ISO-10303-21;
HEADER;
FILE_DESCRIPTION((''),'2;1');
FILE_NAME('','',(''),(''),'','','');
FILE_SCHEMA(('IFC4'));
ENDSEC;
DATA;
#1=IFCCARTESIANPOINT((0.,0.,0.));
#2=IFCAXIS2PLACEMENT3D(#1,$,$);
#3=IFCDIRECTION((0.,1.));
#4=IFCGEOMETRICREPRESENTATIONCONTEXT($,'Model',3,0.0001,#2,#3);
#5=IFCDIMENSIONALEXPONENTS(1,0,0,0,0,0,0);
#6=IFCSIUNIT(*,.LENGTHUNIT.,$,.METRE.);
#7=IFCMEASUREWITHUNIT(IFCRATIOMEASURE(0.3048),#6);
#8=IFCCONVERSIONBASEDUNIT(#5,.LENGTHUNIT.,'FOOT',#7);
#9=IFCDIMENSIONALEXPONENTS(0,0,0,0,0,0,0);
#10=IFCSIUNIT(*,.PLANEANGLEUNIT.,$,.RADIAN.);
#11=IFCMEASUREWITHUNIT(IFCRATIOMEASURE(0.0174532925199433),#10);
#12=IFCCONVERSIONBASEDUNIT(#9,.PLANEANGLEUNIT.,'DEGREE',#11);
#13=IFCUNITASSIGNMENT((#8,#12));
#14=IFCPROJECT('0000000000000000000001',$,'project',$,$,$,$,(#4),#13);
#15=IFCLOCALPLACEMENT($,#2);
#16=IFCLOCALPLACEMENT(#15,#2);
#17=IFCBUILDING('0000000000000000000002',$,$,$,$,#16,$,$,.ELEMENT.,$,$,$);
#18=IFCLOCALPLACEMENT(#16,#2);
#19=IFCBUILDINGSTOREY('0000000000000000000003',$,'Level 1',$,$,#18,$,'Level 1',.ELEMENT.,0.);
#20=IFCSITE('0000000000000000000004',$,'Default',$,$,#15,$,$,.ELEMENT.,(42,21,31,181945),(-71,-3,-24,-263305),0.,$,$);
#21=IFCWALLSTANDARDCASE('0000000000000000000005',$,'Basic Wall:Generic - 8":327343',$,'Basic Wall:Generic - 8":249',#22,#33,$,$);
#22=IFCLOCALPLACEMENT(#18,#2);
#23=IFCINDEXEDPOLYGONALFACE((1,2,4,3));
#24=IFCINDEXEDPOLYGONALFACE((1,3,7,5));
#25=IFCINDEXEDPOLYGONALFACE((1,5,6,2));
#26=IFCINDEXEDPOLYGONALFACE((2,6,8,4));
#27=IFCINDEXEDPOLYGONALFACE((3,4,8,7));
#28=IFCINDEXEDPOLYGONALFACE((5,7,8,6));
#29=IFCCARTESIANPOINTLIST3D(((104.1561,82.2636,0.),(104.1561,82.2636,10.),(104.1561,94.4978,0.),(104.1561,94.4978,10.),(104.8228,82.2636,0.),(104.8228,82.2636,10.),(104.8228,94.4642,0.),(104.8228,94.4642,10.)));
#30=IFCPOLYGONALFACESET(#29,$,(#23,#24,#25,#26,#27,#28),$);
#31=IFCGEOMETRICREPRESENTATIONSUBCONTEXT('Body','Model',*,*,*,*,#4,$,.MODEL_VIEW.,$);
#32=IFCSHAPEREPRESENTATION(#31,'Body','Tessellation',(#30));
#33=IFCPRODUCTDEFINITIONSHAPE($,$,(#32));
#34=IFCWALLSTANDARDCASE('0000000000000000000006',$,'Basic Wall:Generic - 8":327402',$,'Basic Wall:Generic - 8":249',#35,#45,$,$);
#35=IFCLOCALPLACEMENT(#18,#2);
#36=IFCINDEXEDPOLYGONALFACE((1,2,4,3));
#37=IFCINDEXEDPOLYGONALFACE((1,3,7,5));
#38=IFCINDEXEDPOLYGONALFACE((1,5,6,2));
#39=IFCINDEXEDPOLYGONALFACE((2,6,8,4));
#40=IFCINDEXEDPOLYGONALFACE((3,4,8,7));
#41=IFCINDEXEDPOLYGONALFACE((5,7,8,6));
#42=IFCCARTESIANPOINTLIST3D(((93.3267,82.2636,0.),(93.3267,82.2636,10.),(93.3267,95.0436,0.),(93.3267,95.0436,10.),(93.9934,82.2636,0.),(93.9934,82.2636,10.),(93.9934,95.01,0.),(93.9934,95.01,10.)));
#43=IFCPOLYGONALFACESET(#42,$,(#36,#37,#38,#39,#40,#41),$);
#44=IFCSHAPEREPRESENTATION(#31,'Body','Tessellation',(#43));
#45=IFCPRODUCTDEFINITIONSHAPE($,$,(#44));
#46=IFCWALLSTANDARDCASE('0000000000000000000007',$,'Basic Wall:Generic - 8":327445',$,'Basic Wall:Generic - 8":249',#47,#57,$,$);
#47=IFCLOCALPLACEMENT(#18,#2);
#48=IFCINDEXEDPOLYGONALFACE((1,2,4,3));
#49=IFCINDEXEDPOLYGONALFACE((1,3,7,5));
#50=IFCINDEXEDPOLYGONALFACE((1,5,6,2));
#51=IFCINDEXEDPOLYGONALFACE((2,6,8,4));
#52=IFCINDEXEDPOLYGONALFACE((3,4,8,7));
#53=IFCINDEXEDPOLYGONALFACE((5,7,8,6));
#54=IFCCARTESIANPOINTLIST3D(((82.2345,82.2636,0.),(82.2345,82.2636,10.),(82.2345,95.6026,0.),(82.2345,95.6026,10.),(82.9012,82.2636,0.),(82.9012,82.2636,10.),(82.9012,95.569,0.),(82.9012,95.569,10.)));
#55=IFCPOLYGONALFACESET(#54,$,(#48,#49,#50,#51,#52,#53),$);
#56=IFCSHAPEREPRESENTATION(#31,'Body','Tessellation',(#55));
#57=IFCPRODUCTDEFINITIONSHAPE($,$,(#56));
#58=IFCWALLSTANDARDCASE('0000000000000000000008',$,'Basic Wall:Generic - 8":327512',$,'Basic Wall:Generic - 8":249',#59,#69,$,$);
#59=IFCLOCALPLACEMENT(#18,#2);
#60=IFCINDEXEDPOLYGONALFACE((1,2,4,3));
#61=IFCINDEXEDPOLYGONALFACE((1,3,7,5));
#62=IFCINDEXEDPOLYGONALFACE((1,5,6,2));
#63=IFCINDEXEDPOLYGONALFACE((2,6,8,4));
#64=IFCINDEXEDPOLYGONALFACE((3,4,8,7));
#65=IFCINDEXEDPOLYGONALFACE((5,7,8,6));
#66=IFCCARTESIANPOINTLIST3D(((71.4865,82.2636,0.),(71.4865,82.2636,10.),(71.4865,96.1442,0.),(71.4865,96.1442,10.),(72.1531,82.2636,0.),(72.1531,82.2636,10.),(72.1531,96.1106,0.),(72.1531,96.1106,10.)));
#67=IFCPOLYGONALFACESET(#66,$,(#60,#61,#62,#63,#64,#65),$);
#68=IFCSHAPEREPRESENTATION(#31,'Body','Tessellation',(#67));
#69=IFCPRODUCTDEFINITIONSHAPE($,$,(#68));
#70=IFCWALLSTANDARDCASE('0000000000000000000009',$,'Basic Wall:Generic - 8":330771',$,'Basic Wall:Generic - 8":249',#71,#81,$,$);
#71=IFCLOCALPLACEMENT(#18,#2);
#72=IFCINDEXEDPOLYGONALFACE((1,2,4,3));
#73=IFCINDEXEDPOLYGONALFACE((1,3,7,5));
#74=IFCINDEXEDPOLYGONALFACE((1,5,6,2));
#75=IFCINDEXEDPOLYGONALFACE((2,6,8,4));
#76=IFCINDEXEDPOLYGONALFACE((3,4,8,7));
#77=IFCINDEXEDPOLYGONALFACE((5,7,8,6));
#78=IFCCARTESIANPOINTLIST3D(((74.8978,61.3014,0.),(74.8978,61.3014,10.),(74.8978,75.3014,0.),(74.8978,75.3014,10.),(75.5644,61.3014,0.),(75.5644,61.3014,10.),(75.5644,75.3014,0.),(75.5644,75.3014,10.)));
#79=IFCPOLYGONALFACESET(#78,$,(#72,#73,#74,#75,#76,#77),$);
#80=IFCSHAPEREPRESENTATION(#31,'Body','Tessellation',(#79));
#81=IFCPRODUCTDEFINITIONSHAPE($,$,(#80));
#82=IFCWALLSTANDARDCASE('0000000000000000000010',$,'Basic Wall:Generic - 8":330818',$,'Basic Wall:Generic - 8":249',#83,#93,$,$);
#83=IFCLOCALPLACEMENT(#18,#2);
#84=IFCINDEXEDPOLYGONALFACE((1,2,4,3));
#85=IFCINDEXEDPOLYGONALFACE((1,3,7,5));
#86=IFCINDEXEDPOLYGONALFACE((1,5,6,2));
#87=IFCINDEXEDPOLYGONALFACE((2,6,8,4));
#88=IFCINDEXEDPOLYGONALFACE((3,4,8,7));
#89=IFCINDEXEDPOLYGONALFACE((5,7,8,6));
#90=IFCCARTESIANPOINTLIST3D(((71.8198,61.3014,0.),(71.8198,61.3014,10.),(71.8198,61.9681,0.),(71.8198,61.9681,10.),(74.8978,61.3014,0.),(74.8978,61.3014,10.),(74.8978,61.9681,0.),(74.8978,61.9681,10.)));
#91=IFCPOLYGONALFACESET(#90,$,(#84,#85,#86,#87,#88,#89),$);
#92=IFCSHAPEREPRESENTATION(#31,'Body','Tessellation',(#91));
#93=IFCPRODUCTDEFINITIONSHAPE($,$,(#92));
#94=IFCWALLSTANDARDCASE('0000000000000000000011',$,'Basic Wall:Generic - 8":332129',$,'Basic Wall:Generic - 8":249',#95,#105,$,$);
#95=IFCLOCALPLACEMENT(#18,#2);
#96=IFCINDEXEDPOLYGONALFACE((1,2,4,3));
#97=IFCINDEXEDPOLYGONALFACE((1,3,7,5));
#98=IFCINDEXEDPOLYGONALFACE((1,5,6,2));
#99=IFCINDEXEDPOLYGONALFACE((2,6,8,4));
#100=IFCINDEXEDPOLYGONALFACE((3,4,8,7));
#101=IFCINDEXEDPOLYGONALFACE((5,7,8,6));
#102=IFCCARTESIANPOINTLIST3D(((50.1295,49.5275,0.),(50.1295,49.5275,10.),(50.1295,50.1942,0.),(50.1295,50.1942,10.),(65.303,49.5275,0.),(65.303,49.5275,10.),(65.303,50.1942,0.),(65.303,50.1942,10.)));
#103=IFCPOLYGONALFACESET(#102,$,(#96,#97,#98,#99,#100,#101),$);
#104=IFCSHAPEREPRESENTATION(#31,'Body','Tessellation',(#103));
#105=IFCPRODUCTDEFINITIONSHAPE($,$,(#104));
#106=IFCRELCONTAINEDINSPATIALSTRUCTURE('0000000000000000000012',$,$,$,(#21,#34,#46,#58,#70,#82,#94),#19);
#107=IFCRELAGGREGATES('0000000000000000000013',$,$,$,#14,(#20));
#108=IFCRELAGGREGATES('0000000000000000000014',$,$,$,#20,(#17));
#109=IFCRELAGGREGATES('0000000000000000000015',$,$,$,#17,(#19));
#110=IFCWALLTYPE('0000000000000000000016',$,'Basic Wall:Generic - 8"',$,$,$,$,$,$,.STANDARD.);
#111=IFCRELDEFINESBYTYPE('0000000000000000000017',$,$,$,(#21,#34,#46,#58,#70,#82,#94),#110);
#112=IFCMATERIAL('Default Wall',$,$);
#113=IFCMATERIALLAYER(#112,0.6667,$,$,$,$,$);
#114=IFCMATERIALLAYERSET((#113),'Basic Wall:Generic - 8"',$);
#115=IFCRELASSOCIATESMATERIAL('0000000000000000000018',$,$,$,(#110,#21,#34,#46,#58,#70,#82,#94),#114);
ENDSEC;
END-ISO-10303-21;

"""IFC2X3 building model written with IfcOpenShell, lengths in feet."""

from ifc_helpers import new_model, entity, si_unit, converted_unit, direction, frame, frame_2d, origin, place, context, subcontext, project, spatial, polyline, rectangle, outline, extrude, material, layer, layer_set, layer_usage, type_object, element, save


model = new_model("IFC2X3")

# Units and contexts
model_context = context("Model", 3, precision=0.0001, world=origin(), true_north=direction((0.0, 1.0)))
body_context = subcontext(model_context, "Body", "Model", "MODEL_VIEW")
ifc_project = project(units=[converted_unit("LENGTHUNIT", "FOOT", entity("IfcRatioMeasure", 0.3048), si_unit("LENGTHUNIT", "METRE"), dimensions=[1, 0, 0, 0, 0, 0, 0]), converted_unit("PLANEANGLEUNIT", "DEGREE", entity("IfcRatioMeasure", 0.0174532925199433), si_unit("PLANEANGLEUNIT", "RADIAN"), dimensions=[0, 0, 0, 0, 0, 0, 0])], contexts=[model_context])

# Site, building, storey
site_placement = place(None, origin())
site = spatial("IfcSite", under=ifc_project, at=site_placement, Name="Default", CompositionType="ELEMENT", RefLatitude=(42, 21, 31, 181945), RefLongitude=(-71, -3, -24, -263305), RefElevation=0.0)
building_placement = place(site_placement, origin())
building = spatial("IfcBuilding", under=site, at=building_placement, CompositionType="ELEMENT")
storey_placement = place(building_placement, origin())
storey = spatial("IfcBuildingStorey", under=building, at=storey_placement, Name="Level 1", LongName="Level 1", CompositionType="ELEMENT", Elevation=0.0)

# Walls
ifc_material_1 = material(Name="Default Wall")
ifc_layer = layer(ifc_material_1, 0.6667)
ifc_layer_set = layer_set([ifc_layer], Name="Basic Wall:Generic - 8\"")
ifc_layer_usage_1 = layer_usage(ifc_layer_set, "AXIS2", "NEGATIVE", 0.3333)
wall_type = type_object("IfcWallType", Name="Basic Wall:Generic - 8\"", PredefinedType="STANDARD", material=ifc_layer_set)
wall_1_placement = place(storey_placement, frame((104.4894, 94.4978, 0.0), z_axis=(0.0, 0.0, 1.0), x_axis=(0.0, -1.0, 0.0)))
element("IfcWallStandardCase", 1, at=wall_1_placement, inside=storey, type_object=wall_type, material=ifc_layer_usage_1, Name="Basic Wall:Generic - 8\":327343", ObjectType="Basic Wall:Generic - 8\":249", context=body_context, shape_type="SweptSolid", body=[
    extrude(outline(polyline([(12.2342, -0.3333), (12.2342, 0.3333), (0.0336, 0.3333), (0.0, -0.3333), (12.2342, -0.3333)])), origin(), (0.0, 0.0, 1.0), 10.0),
])
ifc_layer_usage_2 = layer_usage(ifc_layer_set, "AXIS2", "NEGATIVE", 0.3333)
wall_2_placement = place(storey_placement, frame((93.6601, 95.0436, 0.0), z_axis=(0.0, 0.0, 1.0), x_axis=(0.0, -1.0, 0.0)))
element("IfcWallStandardCase", 2, at=wall_2_placement, inside=storey, type_object=wall_type, material=ifc_layer_usage_2, Name="Basic Wall:Generic - 8\":327402", ObjectType="Basic Wall:Generic - 8\":249", context=body_context, shape_type="SweptSolid", body=[
    extrude(outline(polyline([(12.78, -0.3333), (12.78, 0.3333), (0.0336, 0.3333), (0.0, -0.3333), (12.78, -0.3333)])), origin(), (0.0, 0.0, 1.0), 10.0),
])
ifc_layer_usage_3 = layer_usage(ifc_layer_set, "AXIS2", "NEGATIVE", 0.3333)
wall_3_placement = place(storey_placement, frame((82.5678, 95.6026, 0.0), z_axis=(0.0, 0.0, 1.0), x_axis=(0.0, -1.0, 0.0)))
element("IfcWallStandardCase", 3, at=wall_3_placement, inside=storey, type_object=wall_type, material=ifc_layer_usage_3, Name="Basic Wall:Generic - 8\":327445", ObjectType="Basic Wall:Generic - 8\":249", context=body_context, shape_type="SweptSolid", body=[
    extrude(outline(polyline([(13.339, -0.3333), (13.339, 0.3333), (0.0336, 0.3333), (0.0, -0.3333), (13.339, -0.3333)])), origin(), (0.0, 0.0, 1.0), 10.0),
])
ifc_layer_usage_4 = layer_usage(ifc_layer_set, "AXIS2", "NEGATIVE", 0.3333)
wall_4_placement = place(storey_placement, frame((71.8198, 96.1442, 0.0), z_axis=(0.0, 0.0, 1.0), x_axis=(0.0, -1.0, 0.0)))
element("IfcWallStandardCase", 4, at=wall_4_placement, inside=storey, type_object=wall_type, material=ifc_layer_usage_4, Name="Basic Wall:Generic - 8\":327512", ObjectType="Basic Wall:Generic - 8\":249", context=body_context, shape_type="SweptSolid", body=[
    extrude(outline(polyline([(13.8807, -0.3333), (13.8807, 0.3333), (0.0336, 0.3333), (0.0, -0.3333), (13.8807, -0.3333)])), origin(), (0.0, 0.0, 1.0), 10.0),
])
ifc_layer_usage_5 = layer_usage(ifc_layer_set, "AXIS2", "NEGATIVE", 0.3333)
wall_5_placement = place(storey_placement, frame((75.2311, 75.3014, 0.0), z_axis=(0.0, 0.0, 1.0), x_axis=(0.0, -1.0, 0.0)))
element("IfcWallStandardCase", 5, at=wall_5_placement, inside=storey, type_object=wall_type, material=ifc_layer_usage_5, Name="Basic Wall:Generic - 8\":330771", ObjectType="Basic Wall:Generic - 8\":249", context=body_context, shape_type="SweptSolid", body=[
    extrude(rectangle(XDim=14.0, YDim=0.6667, at=frame_2d((7.0, 0.0), x_axis=(-1.0, 0.0))), origin(), (0.0, 0.0, 1.0), 10.0),
])
ifc_layer_usage_6 = layer_usage(ifc_layer_set, "AXIS2", "NEGATIVE", 0.3333)
wall_6_placement = place(storey_placement, frame((74.8978, 61.6348, 0.0), z_axis=(0.0, 0.0, 1.0), x_axis=(-1.0, 0.0, 0.0)))
element("IfcWallStandardCase", 6, at=wall_6_placement, inside=storey, type_object=wall_type, material=ifc_layer_usage_6, Name="Basic Wall:Generic - 8\":330818", ObjectType="Basic Wall:Generic - 8\":249", context=body_context, shape_type="SweptSolid", body=[
    extrude(rectangle(XDim=3.0779, YDim=0.6667, at=frame_2d((1.539, 0.0), x_axis=(-1.0, 0.0))), origin(), (0.0, 0.0, 1.0), 10.0),
])
ifc_layer_usage_7 = layer_usage(ifc_layer_set, "AXIS2", "NEGATIVE", 0.3333)
wall_7_placement = place(storey_placement, frame((65.303, 49.8609, 0.0), z_axis=(0.0, 0.0, 1.0), x_axis=(-1.0, 0.0, 0.0)))
element("IfcWallStandardCase", 7, at=wall_7_placement, inside=storey, type_object=wall_type, material=ifc_layer_usage_7, Name="Basic Wall:Generic - 8\":332129", ObjectType="Basic Wall:Generic - 8\":249", context=body_context, shape_type="SweptSolid", body=[
    extrude(rectangle(XDim=15.1735, YDim=0.6667, at=frame_2d((7.5867, 0.0), x_axis=(-1.0, 0.0))), origin(), (0.0, 0.0, 1.0), 10.0),
])

save(model, "model.ifc")
